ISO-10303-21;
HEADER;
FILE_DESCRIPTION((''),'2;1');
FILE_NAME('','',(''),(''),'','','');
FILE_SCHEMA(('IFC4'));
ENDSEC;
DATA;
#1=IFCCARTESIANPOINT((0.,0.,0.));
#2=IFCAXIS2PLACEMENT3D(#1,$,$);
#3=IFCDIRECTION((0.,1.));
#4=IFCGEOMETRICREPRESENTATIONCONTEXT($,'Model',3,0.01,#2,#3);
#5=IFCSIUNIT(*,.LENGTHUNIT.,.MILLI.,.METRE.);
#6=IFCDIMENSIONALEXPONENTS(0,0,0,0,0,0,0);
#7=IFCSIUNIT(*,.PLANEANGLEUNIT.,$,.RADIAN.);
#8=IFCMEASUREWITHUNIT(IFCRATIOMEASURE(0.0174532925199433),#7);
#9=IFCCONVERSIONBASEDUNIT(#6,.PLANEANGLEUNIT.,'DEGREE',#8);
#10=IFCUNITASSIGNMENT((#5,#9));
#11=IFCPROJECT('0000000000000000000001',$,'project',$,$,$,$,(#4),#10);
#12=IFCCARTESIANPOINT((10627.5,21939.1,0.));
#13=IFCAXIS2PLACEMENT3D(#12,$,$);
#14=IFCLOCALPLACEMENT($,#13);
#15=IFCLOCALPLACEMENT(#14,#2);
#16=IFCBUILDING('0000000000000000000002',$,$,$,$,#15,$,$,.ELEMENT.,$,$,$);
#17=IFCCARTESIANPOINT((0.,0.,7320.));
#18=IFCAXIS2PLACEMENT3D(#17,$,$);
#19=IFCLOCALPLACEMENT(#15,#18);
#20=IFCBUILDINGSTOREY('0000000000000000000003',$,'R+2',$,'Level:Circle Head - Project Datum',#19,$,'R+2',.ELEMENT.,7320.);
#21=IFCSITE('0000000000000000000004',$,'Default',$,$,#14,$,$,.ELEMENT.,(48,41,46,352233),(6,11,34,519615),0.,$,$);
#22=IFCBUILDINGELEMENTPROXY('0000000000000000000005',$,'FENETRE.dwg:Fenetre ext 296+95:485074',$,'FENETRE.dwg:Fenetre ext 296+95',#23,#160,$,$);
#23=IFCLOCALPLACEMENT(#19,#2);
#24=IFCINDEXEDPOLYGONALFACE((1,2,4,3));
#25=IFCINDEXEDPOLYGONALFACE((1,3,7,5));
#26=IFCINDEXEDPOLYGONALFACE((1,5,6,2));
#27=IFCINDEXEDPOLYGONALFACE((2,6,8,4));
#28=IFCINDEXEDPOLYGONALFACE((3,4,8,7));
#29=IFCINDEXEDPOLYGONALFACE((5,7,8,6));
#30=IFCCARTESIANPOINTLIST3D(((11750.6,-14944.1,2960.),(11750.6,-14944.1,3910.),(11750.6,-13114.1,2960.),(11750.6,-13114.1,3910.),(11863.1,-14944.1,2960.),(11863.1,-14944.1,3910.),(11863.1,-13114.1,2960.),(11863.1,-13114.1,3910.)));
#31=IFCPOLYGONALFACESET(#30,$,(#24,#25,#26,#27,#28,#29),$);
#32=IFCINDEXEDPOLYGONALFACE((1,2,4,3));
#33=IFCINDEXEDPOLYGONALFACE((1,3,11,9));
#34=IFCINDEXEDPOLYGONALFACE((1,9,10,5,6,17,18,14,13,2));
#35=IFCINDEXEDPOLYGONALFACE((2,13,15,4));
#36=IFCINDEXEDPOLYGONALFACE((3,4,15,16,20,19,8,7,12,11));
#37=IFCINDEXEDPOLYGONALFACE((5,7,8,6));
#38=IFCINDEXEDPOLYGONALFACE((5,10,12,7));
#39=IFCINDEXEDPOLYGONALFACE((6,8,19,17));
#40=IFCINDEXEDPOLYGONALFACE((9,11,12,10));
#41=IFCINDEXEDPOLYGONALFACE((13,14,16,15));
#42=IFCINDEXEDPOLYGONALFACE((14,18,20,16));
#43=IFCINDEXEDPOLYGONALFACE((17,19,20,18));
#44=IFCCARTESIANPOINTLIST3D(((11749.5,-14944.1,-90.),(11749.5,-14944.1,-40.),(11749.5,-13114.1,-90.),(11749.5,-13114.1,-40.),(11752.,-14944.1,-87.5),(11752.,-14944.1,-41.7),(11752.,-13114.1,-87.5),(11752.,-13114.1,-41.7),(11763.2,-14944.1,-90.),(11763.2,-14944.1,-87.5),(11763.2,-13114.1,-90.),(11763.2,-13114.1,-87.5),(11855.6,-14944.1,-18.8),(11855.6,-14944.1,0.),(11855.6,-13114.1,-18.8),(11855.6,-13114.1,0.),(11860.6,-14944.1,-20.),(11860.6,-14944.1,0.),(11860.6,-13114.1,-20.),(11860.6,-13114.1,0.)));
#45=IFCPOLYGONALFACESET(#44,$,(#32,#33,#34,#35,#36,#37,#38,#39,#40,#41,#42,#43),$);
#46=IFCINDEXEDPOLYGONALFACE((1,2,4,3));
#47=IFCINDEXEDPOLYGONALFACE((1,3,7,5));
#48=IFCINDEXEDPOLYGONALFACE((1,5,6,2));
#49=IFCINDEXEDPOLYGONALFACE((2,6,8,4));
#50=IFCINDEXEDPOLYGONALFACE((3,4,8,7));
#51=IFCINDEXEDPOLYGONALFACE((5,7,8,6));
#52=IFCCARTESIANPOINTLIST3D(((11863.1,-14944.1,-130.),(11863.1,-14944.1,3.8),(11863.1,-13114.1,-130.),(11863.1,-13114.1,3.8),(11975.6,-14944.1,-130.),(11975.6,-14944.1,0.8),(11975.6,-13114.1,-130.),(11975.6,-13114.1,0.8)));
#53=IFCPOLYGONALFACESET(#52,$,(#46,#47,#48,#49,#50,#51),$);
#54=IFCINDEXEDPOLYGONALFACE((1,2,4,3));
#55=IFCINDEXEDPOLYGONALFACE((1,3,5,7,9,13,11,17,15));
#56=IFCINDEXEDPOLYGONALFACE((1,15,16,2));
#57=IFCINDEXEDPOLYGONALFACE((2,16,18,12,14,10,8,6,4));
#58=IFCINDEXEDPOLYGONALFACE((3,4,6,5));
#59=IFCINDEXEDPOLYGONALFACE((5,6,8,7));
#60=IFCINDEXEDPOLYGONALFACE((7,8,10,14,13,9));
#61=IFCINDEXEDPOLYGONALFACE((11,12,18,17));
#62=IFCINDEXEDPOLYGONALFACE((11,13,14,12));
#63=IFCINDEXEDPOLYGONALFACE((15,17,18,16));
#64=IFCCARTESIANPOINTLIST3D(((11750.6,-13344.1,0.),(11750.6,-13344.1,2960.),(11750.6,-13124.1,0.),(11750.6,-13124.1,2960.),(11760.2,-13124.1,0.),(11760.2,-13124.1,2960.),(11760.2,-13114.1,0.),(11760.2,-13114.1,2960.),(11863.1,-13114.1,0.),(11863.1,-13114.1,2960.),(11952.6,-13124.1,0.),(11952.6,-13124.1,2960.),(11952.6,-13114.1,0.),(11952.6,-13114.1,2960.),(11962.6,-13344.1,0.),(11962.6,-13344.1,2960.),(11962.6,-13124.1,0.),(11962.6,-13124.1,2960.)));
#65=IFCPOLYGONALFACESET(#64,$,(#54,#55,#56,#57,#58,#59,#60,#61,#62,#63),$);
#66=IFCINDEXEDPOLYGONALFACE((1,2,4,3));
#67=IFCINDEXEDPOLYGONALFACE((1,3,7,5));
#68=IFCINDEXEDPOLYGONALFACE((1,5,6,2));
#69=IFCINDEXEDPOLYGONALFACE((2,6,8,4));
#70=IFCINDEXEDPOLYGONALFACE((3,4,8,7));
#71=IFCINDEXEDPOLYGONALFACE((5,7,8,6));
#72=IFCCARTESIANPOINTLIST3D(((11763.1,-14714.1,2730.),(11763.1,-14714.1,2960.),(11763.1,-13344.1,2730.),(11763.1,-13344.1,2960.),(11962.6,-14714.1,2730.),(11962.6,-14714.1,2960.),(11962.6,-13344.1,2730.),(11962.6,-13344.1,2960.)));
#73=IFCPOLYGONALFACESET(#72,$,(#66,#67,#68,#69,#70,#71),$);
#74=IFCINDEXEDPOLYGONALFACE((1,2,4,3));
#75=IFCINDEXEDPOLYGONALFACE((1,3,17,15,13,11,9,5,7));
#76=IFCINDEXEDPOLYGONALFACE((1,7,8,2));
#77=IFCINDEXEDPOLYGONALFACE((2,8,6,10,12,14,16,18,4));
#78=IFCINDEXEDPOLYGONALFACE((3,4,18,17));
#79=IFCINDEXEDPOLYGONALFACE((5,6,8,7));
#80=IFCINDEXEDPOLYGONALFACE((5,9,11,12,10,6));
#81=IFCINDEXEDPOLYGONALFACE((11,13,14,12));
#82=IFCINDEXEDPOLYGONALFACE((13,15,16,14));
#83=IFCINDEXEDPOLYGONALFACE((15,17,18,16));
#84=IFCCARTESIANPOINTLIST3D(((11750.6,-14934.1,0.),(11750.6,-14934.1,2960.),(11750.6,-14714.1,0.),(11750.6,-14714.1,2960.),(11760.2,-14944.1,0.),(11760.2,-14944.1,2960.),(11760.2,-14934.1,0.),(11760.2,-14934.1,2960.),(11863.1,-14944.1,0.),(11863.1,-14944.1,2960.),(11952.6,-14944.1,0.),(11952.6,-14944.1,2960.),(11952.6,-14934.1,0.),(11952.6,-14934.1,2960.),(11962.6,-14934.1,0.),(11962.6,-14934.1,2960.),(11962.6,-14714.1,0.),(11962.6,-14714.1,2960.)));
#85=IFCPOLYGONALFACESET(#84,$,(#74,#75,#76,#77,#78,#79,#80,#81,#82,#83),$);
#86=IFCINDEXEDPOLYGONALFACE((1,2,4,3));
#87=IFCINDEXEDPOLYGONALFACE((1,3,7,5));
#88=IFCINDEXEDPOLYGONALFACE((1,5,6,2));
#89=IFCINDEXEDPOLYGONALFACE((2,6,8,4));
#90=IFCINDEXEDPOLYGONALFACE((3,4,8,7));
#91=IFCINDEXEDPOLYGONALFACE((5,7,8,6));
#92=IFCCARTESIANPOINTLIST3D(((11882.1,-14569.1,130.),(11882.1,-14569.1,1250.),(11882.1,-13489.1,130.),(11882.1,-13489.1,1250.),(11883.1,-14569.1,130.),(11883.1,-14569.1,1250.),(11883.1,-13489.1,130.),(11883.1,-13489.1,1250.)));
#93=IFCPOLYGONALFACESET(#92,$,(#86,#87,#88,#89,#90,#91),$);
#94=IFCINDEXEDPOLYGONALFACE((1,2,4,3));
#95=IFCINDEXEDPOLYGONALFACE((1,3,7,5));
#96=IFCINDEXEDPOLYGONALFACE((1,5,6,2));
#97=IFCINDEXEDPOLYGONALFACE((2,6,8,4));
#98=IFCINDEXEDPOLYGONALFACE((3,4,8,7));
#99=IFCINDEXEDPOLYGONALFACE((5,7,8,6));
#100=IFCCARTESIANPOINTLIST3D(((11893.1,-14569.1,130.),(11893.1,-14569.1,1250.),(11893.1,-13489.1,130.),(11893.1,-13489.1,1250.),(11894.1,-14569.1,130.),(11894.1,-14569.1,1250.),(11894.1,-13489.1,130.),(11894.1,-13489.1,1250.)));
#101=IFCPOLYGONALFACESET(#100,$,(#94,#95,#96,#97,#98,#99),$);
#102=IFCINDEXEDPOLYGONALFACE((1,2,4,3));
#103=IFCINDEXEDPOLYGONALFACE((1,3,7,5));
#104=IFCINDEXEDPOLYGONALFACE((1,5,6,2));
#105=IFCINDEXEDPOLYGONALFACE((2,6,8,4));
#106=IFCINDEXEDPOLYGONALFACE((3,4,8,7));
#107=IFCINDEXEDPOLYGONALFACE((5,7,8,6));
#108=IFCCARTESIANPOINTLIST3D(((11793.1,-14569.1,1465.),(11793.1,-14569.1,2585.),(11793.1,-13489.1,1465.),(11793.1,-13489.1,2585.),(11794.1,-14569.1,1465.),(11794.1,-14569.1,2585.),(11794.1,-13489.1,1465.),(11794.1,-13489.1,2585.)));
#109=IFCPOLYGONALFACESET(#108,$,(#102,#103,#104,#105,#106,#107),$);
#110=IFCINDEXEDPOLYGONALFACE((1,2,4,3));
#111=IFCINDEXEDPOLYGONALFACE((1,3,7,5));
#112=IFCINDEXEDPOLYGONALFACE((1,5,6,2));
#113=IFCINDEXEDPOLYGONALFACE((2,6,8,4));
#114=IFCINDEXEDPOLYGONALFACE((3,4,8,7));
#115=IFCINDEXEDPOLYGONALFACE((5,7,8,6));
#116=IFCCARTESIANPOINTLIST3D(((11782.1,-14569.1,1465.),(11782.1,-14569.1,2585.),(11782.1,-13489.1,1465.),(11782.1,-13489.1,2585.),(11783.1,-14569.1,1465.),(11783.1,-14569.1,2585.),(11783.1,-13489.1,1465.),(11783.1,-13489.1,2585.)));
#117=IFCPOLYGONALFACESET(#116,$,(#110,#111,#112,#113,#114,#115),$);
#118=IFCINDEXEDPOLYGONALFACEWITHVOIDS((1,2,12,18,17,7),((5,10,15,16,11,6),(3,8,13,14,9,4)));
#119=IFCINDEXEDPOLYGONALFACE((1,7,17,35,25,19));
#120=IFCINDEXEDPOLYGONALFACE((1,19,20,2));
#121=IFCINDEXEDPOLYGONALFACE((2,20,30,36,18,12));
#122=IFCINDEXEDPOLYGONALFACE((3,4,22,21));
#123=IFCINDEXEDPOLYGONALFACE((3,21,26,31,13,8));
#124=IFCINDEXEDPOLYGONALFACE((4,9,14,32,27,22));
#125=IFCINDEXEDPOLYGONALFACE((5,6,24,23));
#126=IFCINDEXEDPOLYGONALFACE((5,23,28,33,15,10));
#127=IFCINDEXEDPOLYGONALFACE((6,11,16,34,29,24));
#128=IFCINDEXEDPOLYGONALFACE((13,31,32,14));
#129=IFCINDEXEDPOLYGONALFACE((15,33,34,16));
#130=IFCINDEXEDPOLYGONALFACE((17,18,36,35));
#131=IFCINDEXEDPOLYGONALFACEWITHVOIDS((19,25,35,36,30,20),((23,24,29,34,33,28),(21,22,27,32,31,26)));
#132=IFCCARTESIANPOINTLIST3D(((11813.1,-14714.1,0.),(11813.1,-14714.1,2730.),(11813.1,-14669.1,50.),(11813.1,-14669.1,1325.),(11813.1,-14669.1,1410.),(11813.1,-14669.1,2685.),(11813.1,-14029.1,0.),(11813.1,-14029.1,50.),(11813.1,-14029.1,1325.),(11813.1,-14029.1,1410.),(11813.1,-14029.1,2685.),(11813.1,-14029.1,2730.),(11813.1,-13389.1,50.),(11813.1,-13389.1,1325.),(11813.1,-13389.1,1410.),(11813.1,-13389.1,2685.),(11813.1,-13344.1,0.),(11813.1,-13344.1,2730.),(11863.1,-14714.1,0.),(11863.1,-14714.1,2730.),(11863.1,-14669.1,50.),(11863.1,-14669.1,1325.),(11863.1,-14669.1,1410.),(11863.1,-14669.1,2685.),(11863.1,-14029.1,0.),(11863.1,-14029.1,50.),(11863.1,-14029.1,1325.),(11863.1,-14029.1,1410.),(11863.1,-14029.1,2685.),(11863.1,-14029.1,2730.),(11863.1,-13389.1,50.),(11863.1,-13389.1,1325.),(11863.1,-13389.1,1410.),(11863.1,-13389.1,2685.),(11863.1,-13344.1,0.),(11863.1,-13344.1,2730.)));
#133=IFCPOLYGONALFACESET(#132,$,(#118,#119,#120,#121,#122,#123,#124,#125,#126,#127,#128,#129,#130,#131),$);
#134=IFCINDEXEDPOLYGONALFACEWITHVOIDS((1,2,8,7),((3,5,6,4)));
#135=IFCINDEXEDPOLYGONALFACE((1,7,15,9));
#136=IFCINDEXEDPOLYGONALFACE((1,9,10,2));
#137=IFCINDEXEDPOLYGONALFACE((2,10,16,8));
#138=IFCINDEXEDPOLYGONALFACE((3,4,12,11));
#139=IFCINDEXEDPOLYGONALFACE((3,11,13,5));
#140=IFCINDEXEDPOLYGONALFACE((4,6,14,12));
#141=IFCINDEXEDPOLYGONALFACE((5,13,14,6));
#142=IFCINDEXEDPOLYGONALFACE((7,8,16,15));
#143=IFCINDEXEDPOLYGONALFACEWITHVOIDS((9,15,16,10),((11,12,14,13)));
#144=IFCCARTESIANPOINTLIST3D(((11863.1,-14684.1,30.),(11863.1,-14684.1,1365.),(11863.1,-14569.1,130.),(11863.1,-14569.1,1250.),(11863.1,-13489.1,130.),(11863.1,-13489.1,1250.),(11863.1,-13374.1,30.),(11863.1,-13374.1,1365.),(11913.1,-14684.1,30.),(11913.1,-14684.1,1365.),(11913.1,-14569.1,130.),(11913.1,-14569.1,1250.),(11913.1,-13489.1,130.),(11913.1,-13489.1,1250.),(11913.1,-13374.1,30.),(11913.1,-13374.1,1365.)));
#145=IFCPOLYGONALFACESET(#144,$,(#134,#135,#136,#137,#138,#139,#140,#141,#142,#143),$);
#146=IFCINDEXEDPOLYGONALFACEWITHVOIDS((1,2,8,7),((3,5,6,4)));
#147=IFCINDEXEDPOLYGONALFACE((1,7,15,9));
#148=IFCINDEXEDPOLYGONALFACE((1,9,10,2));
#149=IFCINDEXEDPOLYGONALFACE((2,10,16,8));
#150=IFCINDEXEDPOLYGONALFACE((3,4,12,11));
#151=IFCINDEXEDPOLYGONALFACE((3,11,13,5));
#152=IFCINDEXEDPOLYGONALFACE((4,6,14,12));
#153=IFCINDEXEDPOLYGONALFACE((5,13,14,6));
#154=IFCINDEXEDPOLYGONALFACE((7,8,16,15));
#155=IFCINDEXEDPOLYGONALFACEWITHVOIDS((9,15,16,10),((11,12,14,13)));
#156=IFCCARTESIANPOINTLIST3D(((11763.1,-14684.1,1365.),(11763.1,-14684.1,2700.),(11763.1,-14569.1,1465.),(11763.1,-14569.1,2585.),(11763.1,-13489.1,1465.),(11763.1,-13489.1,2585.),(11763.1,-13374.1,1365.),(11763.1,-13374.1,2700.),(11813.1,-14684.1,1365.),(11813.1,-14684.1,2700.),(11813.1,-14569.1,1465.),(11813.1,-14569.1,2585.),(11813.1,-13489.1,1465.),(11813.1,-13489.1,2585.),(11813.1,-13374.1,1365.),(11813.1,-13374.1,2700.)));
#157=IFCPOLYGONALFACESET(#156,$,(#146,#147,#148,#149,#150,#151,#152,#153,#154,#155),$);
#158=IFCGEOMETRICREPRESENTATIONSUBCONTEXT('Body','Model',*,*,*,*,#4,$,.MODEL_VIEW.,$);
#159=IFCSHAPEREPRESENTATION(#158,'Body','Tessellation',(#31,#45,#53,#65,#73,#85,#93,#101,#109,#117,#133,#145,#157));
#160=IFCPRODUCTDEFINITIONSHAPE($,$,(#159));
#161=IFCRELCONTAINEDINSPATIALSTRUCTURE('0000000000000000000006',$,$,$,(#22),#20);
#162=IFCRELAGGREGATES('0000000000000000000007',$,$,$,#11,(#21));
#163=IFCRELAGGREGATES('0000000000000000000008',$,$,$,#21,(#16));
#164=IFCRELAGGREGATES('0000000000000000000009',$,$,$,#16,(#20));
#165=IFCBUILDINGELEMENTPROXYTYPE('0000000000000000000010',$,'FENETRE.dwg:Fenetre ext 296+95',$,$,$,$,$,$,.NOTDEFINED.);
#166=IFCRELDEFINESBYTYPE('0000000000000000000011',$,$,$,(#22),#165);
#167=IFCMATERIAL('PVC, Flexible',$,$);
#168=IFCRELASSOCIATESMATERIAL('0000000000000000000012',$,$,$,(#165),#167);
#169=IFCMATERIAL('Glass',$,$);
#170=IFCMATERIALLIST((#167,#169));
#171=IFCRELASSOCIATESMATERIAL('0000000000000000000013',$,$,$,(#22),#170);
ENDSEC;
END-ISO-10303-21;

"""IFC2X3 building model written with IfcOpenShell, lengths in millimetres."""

from ifc_helpers import new_model, entity, si_unit, converted_unit, direction, frame, frame_2d, origin, origin_2d_with_axis, place, context, subcontext, project, spatial, polyline, rectangle, outline, extrude, source, transform, mapped, material, material_list, type_object, type_shapes, element, save


model = new_model("IFC2X3")

# Units and contexts
model_context = context("Model", 3, precision=0.01, world=origin(), true_north=direction((0.0, 1.0)))
body_context = subcontext(model_context, "Body", "Model", "MODEL_VIEW")
ifc_project = project(units=[si_unit("LENGTHUNIT", "METRE", prefix="MILLI"), converted_unit("PLANEANGLEUNIT", "DEGREE", entity("IfcRatioMeasure", 0.0174532925199433), si_unit("PLANEANGLEUNIT", "RADIAN"), dimensions=[0, 0, 0, 0, 0, 0, 0])], contexts=[model_context])

# Site, building, storey
site_placement = place(None, frame((10627.5, 21939.1, 0.0)))
site = spatial("IfcSite", under=ifc_project, at=site_placement, Name="Default", CompositionType="ELEMENT", RefLatitude=(48, 41, 46, 352233), RefLongitude=(6, 11, 34, 519615), RefElevation=0.0)
building_placement = place(site_placement, origin())
building = spatial("IfcBuilding", under=site, at=building_placement, CompositionType="ELEMENT")
storey_placement = place(building_placement, frame((0.0, 0.0, 7320.0)))
storey = spatial("IfcBuildingStorey", under=building, at=storey_placement, Name="R+2", ObjectType="Level:Circle Head - Project Datum", LongName="R+2", CompositionType="ELEMENT", Elevation=7320.0)

# Building element proxy
ifc_material_1 = material(Name="PVC, Flexible")
ifc_material_2 = material(Name="Glass")
building_element_proxy_type_1 = type_object("IfcBuildingElementProxyType", Name="FENETRE.dwg:Fenetre ext 296+95", PredefinedType="NOTDEFINED", material=ifc_material_1)
shared_shape_1 = source(origin(), body_context, "Body", "SweptSolid", [
    extrude(rectangle(XDim=1830.0, YDim=112.5, at=origin_2d_with_axis()), frame((-10.4, 56.3, 2960.0), z_axis=(0.0, 0.0, 1.0), x_axis=(-1.0, 0.0, 0.0)), (0.0, 0.0, 1.0), 950.0),
    extrude(outline(polyline([(-68.6, -14.4), (-72.5, -34.0), (-67.6, -35.0), (-63.9, -16.6), (44.3, -16.6), (54.1, 32.5), (40.6, 35.2), (40.1, 32.7), (51.2, 30.5), (42.2, -14.4), (-68.6, -14.4)])), frame((-925.4, 66.9, -47.5), z_axis=(-1.0, 0.0, 0.0), x_axis=(0.0, 0.980599, -0.196027)), (0.0, 0.0, -1.0), 1830.0),
    extrude(outline(polyline([(-64.7, -56.3), (66.2, -56.3), (66.2, 56.3), (-67.7, 56.3), (-64.7, -56.3)])), frame((-925.4, -56.3, -63.8), z_axis=(1.0, 0.0, 0.0), x_axis=(0.0, 0.0, -1.0)), (0.0, 0.0, 1.0), 1830.0),
    extrude(outline(polyline([(-55.6, 97.0), (-55.6, -5.9), (-55.6, -95.4), (-45.6, -95.4), (-45.6, -105.4), (174.4, -105.4), (174.4, 106.6), (-45.6, 106.6), (-45.6, 97.0), (-55.6, 97.0)])), frame((849.0, 5.9, 0.0), z_axis=(0.0, 0.0, -1.0), x_axis=(-1.0, 0.0, 0.0)), (0.0, 0.0, -1.0), 2960.0),
    extrude(rectangle(XDim=199.5, YDim=1370.0, at=origin_2d_with_axis()), frame((-10.4, 0.3, 2730.0), z_axis=(0.0, 0.0, 1.0), x_axis=(0.0, 1.0, 0.0)), (0.0, 0.0, 1.0), 230.0),
    extrude(outline(polyline([(-97.0, -55.6), (5.9, -55.6), (95.4, -55.6), (95.4, -45.6), (105.4, -45.6), (105.4, 174.4), (-106.6, 174.4), (-106.6, -45.6), (-97.0, -45.6), (-97.0, -55.6)])), frame((-869.9, 5.9, 0.0), z_axis=(0.0, 0.0, 1.0), x_axis=(0.0, -1.0, 0.0)), (0.0, 0.0, 1.0), 2960.0),
    extrude(rectangle(XDim=1.0, YDim=1080.0, at=origin_2d_with_axis()), frame((-10.4, -19.5, 130.0), z_axis=(0.0, 0.0, 1.0), x_axis=(0.0, 1.0, 0.0)), (0.0, 0.0, 1.0), 1120.0),
    extrude(rectangle(XDim=1.0, YDim=1080.0, at=frame_2d((0.0, 0.0), x_axis=(1.0, 0.0))), frame((-10.4, -30.5, 130.0), z_axis=(0.0, 0.0, 1.0), x_axis=(0.0, 1.0, 0.0)), (0.0, 0.0, 1.0), 1120.0),
    extrude(rectangle(XDim=1.0, YDim=1080.0, at=frame_2d((0.0, 0.0), x_axis=(1.0, 0.0))), frame((-10.4, 69.5, 1465.0), z_axis=(0.0, 0.0, 1.0), x_axis=(0.0, 1.0, 0.0)), (0.0, 0.0, 1.0), 1120.0),
    extrude(rectangle(XDim=1.0, YDim=1080.0, at=frame_2d((0.0, 0.0), x_axis=(1.0, 0.0))), frame((-10.4, 80.5, 1465.0), z_axis=(0.0, 0.0, 1.0), x_axis=(0.0, 1.0, 0.0)), (0.0, 0.0, 1.0), 1120.0),
    extrude(outline(polyline([(-685.0, -1365.0), (0.0, -1365.0), (685.0, -1365.0), (685.0, 1365.0), (0.0, 1365.0), (-685.0, 1365.0), (-685.0, -1365.0)]), holes=[polyline([(-640.0, -1320.0), (-640.0, -45.0), (0.0, -45.0), (640.0, -45.0), (640.0, -1320.0), (0.0, -1320.0), (-640.0, -1320.0)]), polyline([(-640.0, 40.0), (-640.0, 1315.0), (0.0, 1315.0), (640.0, 1315.0), (640.0, 40.0), (0.0, 40.0), (-640.0, 40.0)])]), frame((-10.4, 0.0, 1365.0), z_axis=(0.0, 1.0, 0.0), x_axis=(1.0, 0.0, 0.0)), (0.0, 0.0, 1.0), 50.0),
    extrude(outline(polyline([(-655.0, -667.5), (655.0, -667.5), (655.0, 667.5), (-655.0, 667.5), (-655.0, -667.5)]), holes=[polyline([(-540.0, 552.5), (540.0, 552.5), (540.0, -567.5), (-540.0, -567.5), (-540.0, 552.5)])]), frame((-10.4, -50.0, 697.5), z_axis=(0.0, 1.0, 0.0), x_axis=(-1.0, 0.0, 0.0)), (0.0, 0.0, 1.0), 50.0),
    extrude(outline(polyline([(-655.0, -667.5), (655.0, -667.5), (655.0, 667.5), (-655.0, 667.5), (-655.0, -667.5)]), holes=[polyline([(-540.0, 552.5), (540.0, 552.5), (540.0, -567.5), (-540.0, -567.5), (-540.0, 552.5)])]), frame((-10.4, 50.0, 2032.5), z_axis=(0.0, 1.0, 0.0), x_axis=(-1.0, 0.0, 0.0)), (0.0, 0.0, 1.0), 50.0),
])
type_shapes(building_element_proxy_type_1, [shared_shape_1])
ifc_material_list_1 = material_list([ifc_material_1, ifc_material_2])
proxy_1_placement = place(storey_placement, frame((11863.1, -14018.7, 0.0), z_axis=(0.0, 0.0, 1.0), x_axis=(0.0, 1.0, 0.0)))
element("IfcBuildingElementProxy", 1, at=proxy_1_placement, inside=storey, type_object=building_element_proxy_type_1, material=ifc_material_list_1, Name="FENETRE.dwg:Fenetre ext 296+95:485074", ObjectType="FENETRE.dwg:Fenetre ext 296+95", context=body_context, shape_type="MappedRepresentation", body=[
    mapped(shared_shape_1, transform((0.0, 0.0, 0.0), scale=1.0)),
])

save(model, "model.ifc")
